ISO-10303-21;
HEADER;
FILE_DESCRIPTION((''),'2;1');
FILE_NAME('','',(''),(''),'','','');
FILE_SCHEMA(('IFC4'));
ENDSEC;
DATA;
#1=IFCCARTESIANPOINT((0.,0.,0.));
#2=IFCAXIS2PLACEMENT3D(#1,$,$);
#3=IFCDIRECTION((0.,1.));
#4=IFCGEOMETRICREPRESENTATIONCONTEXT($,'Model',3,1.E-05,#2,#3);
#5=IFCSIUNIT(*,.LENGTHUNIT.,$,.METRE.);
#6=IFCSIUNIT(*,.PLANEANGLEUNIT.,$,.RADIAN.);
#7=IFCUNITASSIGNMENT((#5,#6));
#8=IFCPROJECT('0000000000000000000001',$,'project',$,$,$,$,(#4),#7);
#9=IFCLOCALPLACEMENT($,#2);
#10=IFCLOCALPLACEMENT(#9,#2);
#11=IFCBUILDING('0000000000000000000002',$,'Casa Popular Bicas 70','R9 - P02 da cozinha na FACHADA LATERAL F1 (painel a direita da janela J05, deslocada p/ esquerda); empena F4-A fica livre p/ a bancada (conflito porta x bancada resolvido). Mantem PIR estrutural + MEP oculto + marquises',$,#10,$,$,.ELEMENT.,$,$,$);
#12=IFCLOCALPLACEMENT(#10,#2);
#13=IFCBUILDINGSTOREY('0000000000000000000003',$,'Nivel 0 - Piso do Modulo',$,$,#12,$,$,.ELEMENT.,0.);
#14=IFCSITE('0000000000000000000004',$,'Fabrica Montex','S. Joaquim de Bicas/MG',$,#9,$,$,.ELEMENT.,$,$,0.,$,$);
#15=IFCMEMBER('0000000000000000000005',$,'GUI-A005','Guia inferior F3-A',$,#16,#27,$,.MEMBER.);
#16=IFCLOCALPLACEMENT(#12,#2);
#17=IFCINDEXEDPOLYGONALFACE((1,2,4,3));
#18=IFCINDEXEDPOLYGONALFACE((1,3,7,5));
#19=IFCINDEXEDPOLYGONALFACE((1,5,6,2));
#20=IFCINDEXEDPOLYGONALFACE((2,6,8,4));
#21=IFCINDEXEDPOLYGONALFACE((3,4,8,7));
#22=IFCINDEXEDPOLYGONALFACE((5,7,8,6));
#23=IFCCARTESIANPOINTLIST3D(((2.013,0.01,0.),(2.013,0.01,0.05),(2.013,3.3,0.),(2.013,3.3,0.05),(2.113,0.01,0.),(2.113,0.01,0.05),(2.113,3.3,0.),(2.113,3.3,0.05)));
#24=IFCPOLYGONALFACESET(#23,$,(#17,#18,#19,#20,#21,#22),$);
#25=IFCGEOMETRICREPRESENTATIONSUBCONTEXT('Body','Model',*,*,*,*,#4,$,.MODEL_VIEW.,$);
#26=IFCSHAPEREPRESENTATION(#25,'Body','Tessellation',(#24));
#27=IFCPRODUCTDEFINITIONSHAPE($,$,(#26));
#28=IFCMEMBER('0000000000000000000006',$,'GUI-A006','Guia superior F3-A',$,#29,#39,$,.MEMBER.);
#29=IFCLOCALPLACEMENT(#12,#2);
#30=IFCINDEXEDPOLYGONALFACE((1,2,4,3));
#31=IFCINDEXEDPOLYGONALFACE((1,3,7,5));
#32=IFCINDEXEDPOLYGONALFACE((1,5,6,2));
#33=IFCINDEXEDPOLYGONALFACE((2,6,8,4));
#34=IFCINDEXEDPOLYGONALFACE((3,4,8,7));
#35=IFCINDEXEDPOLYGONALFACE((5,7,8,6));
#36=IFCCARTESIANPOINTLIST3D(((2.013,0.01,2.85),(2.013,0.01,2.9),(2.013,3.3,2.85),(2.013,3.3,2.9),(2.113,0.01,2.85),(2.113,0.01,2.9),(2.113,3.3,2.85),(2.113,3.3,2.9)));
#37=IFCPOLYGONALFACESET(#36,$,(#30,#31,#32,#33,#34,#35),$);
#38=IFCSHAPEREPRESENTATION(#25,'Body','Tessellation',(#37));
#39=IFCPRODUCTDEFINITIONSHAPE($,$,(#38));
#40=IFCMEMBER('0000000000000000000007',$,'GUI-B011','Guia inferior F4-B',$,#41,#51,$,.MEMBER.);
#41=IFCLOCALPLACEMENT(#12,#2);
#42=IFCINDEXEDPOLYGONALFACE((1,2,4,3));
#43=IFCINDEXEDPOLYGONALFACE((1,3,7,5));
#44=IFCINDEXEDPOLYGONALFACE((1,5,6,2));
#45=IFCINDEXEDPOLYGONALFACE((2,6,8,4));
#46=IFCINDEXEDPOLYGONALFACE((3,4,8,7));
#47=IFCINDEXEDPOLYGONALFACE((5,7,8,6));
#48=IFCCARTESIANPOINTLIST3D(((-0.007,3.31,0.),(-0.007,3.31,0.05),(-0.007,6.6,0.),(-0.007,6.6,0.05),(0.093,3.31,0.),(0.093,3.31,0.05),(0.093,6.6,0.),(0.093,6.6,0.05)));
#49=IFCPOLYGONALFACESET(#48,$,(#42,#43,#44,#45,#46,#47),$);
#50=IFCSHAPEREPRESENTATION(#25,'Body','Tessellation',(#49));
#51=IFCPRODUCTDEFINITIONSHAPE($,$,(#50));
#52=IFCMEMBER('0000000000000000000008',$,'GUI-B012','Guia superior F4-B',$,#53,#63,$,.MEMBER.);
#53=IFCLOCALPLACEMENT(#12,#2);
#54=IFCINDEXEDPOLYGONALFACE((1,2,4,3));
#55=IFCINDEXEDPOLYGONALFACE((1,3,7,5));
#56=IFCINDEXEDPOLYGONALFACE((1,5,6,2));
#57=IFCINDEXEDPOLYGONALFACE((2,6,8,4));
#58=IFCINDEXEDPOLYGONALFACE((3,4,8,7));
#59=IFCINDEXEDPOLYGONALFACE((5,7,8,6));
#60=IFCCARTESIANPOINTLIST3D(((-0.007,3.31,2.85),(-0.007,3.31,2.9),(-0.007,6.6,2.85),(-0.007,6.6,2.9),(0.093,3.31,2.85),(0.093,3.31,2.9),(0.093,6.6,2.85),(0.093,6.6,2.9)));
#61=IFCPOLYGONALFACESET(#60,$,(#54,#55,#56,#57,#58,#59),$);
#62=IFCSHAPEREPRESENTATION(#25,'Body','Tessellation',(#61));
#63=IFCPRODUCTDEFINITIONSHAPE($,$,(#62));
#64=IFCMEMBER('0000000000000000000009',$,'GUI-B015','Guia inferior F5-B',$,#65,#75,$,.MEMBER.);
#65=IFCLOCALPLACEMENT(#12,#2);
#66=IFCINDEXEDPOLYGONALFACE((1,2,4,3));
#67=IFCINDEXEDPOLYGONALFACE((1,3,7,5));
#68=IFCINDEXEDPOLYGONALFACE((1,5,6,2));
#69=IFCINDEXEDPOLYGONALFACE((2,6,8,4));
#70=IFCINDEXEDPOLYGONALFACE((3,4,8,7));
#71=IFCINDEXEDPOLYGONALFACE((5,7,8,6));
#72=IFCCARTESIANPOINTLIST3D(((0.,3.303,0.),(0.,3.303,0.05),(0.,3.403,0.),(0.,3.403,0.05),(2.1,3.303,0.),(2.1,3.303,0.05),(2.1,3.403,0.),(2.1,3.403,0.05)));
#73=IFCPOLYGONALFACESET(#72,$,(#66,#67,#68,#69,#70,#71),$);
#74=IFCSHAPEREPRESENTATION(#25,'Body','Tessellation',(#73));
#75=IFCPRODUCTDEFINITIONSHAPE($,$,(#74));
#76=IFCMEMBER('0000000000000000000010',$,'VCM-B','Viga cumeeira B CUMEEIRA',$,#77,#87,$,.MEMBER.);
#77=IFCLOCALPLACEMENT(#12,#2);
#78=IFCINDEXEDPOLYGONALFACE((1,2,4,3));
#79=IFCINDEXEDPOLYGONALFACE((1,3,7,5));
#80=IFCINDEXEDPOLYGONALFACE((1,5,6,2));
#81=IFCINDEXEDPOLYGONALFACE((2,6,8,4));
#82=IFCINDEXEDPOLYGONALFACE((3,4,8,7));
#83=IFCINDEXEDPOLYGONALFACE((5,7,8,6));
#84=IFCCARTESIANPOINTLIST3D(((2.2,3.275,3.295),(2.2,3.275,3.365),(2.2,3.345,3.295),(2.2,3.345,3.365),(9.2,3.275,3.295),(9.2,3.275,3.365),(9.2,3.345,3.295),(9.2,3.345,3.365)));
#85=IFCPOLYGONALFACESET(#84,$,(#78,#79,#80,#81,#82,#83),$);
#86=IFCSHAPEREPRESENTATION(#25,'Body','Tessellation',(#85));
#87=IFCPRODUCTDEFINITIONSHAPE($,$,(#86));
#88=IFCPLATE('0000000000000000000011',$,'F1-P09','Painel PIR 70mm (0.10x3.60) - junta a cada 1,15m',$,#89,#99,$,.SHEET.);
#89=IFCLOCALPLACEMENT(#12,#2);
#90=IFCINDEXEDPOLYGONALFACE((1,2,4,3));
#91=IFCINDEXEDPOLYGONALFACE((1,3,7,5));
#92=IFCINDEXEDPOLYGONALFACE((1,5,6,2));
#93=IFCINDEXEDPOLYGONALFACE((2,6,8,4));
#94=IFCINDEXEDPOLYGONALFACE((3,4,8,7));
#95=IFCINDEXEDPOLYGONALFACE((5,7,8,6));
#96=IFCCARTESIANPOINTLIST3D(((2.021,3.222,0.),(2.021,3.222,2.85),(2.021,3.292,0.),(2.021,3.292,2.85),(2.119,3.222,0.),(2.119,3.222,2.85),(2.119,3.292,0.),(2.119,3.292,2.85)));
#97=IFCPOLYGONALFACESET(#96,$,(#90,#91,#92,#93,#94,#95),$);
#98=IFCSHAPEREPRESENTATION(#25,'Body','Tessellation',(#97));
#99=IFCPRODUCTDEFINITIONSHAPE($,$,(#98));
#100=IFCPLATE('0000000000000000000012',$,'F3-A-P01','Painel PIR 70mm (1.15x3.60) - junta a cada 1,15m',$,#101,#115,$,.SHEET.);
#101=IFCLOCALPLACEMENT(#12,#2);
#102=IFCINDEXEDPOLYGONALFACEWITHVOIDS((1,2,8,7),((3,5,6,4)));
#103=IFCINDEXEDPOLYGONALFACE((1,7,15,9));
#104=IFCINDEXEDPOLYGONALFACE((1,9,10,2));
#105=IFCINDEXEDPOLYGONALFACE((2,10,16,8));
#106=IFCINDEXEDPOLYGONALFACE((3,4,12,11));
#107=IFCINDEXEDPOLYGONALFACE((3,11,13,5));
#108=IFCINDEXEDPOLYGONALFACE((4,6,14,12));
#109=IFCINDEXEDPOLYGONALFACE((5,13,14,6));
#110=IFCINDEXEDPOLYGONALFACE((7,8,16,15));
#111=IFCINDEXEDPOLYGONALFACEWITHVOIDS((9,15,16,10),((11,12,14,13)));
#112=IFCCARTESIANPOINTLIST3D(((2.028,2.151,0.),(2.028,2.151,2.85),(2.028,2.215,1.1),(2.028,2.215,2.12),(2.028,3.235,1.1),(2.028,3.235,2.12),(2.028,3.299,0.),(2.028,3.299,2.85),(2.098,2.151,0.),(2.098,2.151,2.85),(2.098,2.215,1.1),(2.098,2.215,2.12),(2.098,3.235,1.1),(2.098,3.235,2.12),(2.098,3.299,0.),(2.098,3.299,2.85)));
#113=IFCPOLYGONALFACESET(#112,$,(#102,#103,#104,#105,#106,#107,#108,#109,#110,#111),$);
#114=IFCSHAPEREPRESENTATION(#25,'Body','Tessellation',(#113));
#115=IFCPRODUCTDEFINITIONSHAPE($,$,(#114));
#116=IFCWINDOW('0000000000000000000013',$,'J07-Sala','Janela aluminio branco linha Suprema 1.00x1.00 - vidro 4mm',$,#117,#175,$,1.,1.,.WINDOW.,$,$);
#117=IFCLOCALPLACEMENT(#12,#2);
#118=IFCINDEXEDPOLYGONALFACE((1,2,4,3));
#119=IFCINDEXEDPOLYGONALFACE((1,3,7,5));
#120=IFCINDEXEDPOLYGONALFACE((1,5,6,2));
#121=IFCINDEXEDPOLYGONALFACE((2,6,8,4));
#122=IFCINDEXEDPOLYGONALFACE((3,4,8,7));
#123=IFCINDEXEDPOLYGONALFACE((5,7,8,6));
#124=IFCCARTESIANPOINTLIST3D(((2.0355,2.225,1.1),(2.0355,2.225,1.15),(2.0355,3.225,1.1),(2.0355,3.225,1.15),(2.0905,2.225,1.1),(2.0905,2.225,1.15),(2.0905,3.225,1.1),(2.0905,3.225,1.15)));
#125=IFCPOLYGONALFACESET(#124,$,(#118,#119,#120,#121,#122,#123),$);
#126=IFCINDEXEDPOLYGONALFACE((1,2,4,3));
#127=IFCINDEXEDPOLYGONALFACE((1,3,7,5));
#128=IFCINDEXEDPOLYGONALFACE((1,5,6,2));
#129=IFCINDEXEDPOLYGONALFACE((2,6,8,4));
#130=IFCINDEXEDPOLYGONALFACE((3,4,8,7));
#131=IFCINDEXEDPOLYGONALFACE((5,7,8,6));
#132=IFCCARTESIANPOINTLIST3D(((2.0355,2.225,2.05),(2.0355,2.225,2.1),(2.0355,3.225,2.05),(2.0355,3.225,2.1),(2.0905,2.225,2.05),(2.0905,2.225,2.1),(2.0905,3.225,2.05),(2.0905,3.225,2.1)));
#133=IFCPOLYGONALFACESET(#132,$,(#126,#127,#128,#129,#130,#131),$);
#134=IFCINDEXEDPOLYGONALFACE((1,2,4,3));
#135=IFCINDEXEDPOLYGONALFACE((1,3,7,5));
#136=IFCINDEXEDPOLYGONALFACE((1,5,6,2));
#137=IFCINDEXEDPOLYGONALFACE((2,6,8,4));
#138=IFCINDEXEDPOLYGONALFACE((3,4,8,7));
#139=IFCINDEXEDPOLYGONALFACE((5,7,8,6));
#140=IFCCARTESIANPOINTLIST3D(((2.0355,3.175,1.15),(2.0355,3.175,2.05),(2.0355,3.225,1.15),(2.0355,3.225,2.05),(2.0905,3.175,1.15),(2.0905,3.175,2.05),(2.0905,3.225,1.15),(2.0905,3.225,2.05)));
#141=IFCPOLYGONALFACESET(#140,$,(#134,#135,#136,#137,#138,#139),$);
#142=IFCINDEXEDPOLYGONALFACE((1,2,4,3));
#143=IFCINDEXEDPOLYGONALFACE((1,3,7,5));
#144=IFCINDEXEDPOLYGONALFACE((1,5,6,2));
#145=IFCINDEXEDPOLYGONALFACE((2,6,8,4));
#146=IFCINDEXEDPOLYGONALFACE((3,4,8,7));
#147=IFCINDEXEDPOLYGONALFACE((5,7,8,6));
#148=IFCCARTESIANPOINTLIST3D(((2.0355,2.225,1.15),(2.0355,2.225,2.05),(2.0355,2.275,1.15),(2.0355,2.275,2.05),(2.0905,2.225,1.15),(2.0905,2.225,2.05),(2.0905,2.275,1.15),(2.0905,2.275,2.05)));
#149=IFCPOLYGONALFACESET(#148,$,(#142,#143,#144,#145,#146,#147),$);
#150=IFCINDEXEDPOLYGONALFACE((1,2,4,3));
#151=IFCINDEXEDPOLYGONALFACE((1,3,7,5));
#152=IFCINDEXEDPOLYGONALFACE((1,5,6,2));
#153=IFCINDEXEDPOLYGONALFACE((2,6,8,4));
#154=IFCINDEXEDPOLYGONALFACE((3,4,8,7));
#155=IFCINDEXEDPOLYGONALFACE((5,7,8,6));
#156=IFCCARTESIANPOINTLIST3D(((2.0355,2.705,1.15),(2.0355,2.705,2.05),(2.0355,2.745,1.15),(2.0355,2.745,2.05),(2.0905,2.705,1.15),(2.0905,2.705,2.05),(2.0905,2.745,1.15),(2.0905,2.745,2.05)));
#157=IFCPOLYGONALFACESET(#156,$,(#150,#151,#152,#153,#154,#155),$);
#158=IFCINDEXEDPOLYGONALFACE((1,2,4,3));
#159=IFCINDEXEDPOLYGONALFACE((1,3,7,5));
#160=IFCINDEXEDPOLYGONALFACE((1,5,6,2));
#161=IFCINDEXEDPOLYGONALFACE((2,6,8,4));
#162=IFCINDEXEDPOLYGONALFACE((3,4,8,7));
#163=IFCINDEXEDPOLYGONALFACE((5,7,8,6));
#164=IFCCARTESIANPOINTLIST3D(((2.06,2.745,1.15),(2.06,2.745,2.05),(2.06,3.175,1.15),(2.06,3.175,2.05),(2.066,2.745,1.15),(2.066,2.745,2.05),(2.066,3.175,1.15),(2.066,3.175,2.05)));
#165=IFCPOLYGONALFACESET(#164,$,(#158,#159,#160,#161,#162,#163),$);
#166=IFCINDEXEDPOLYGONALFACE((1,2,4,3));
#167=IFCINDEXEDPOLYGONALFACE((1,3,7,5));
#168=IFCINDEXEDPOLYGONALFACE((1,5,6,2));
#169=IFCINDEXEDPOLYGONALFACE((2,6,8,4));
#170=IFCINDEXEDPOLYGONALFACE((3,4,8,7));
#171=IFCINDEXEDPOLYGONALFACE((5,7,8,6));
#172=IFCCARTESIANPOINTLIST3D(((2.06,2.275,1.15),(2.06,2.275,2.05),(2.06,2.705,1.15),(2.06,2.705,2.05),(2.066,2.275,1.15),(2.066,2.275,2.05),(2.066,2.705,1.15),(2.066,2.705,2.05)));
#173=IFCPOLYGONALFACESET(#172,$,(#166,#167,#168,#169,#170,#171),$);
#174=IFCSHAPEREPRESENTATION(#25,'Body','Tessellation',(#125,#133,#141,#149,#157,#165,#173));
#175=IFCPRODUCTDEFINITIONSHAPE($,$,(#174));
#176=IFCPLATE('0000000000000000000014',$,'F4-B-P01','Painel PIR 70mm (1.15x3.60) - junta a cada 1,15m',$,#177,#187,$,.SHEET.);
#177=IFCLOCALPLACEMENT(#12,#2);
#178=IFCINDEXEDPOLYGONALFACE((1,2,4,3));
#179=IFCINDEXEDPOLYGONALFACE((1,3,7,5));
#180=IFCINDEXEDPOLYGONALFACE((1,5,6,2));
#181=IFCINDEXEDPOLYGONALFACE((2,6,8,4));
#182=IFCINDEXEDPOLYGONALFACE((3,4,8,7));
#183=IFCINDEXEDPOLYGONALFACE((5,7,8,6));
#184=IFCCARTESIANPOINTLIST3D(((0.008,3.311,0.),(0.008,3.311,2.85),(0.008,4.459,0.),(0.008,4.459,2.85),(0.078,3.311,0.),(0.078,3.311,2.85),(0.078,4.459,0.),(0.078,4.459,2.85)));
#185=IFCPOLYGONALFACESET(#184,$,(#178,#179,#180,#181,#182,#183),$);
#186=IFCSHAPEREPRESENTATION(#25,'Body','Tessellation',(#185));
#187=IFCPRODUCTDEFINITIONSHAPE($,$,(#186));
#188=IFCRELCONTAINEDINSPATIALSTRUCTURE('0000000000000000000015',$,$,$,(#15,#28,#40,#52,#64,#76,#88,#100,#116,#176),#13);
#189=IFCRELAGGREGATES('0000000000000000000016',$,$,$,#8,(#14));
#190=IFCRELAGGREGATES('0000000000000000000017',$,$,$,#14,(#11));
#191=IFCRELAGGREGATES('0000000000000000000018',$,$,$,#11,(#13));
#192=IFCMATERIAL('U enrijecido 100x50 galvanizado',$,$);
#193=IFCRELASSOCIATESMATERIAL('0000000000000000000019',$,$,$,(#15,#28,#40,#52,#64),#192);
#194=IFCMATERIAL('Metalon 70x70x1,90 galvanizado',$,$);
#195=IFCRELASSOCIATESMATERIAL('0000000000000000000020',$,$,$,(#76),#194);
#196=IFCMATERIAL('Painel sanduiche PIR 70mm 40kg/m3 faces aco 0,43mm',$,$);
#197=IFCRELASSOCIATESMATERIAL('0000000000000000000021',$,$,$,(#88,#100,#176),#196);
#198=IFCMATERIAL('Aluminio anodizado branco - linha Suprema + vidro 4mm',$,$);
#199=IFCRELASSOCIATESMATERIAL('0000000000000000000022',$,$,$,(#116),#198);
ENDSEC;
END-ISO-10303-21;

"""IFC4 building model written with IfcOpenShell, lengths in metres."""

from ifc_helpers import new_model, si_unit, direction, frame, frame_2d, origin, origin_2d, place, context, subcontext, project, spatial, rectangle, extrude, material, element, fill, save


model = new_model("IFC4")

# Units and contexts
model_context = context("Model", 3, precision=1e-05, world=origin(), true_north=direction((0.0, 1.0)))
body_context = subcontext(model_context, "Body", "Model", "MODEL_VIEW")
ifc_project = project(units=[si_unit("LENGTHUNIT", "METRE"), si_unit("PLANEANGLEUNIT", "RADIAN")], contexts=[model_context])

# Site, building, storey
site_placement = place(None, origin())
site = spatial("IfcSite", under=ifc_project, at=site_placement, Name="Fabrica Montex", Description="S. Joaquim de Bicas/MG", CompositionType="ELEMENT", RefElevation=0.0)
building_placement = place(site_placement, origin())
building = spatial("IfcBuilding", under=site, at=building_placement, Name="Casa Popular Bicas 70", Description="R9 - P02 da cozinha na FACHADA LATERAL F1 (painel a direita da janela J05, deslocada p/ esquerda); empena F4-A fica livre p/ a bancada (conflito porta x bancada resolvido). Mantem PIR estrutural + MEP oculto + marquises", CompositionType="ELEMENT")
storey_placement = place(building_placement, origin())
storey = spatial("IfcBuildingStorey", under=building, at=storey_placement, Name="Nivel 0 - Piso do Modulo", CompositionType="ELEMENT", Elevation=0.0)

# Members
ifc_material_1 = material(Name="U enrijecido 100x50 galvanizado")
for number, where, z_axis, x_axis, name, description in (
    (1, (2.063, 3.3, 0.025), (0.0, -1.0, 0.0), (0.0, 0.0, 1.0), "GUI-A005", "Guia inferior F3-A"),
    (2, (2.063, 3.3, 2.875), (0.0, -1.0, 0.0), (0.0, 0.0, 1.0), "GUI-A006", "Guia superior F3-A"),
):
    element("IfcMember", number, at=place(None, frame(where, z_axis=z_axis, x_axis=x_axis)), inside=storey, material=ifc_material_1, Name=name, Description=description, PredefinedType="MEMBER", context=body_context, shape_type="SweptSolid", body=[
        extrude(rectangle(XDim=0.05, YDim=0.1, at=origin_2d()), origin(), (0.0, 0.0, 1.0), 3.29),
    ])
for number, where, z_axis, x_axis, name, description in (
    (3, (0.043, 3.31, 0.025), (0.0, 1.0, 0.0), (0.0, 0.0, 1.0), "GUI-B011", "Guia inferior F4-B"),
    (4, (0.043, 3.31, 2.875), (0.0, 1.0, 0.0), (0.0, 0.0, 1.0), "GUI-B012", "Guia superior F4-B"),
):
    element("IfcMember", number, at=place(storey_placement, frame(where, z_axis=z_axis, x_axis=x_axis)), inside=storey, material=ifc_material_1, Name=name, Description=description, PredefinedType="MEMBER", context=body_context, shape_type="SweptSolid", body=[
        extrude(rectangle(XDim=0.05, YDim=0.1, at=origin_2d()), origin(), (0.0, 0.0, 1.0), 3.29),
    ])
member_1_placement = place(storey_placement, frame((0.0, 3.353, 0.025), z_axis=(1.0, 0.0, 0.0), x_axis=(0.0, 0.0, 1.0)))
element("IfcMember", 5, at=member_1_placement, inside=storey, material=ifc_material_1, Name="GUI-B015", Description="Guia inferior F5-B", PredefinedType="MEMBER", context=body_context, shape_type="SweptSolid", body=[
    extrude(rectangle(XDim=0.05, YDim=0.1, at=origin_2d()), origin(), (0.0, 0.0, 1.0), 2.1),
])
ifc_material_2 = material(Name="Metalon 70x70x1,90 galvanizado")
member_2_placement = place(storey_placement, frame((2.2, 3.31, 3.33), z_axis=(1.0, 0.0, 0.0), x_axis=(0.0, 0.0, 1.0)))
element("IfcMember", 6, at=member_2_placement, inside=storey, material=ifc_material_2, Name="VCM-B", Description="Viga cumeeira B CUMEEIRA", PredefinedType="MEMBER", context=body_context, shape_type="SweptSolid", body=[
    extrude(rectangle(XDim=0.07, YDim=0.07, at=origin_2d()), origin(), (0.0, 0.0, 1.0), 7.0),
])

# Plate
ifc_material_3 = material(Name="Painel sanduiche PIR 70mm 40kg/m3 faces aco 0,43mm")
plate_1_placement = place(None, frame((2.119, 3.257, 0.0), z_axis=(0.0, 0.0, 1.0), x_axis=(-1.0, 0.0, 0.0)))
element("IfcPlate", 7, at=plate_1_placement, inside=storey, material=ifc_material_3, Name="F1-P09", Description="Painel PIR 70mm (0.10x3.60) - junta a cada 1,15m", PredefinedType="SHEET", context=body_context, shape_type="SweptSolid", body=[
    extrude(rectangle(XDim=0.098, YDim=0.07, at=frame_2d((0.049, 0.0))), origin(), (0.0, 0.0, 1.0), 2.85),
])

# Plate, opening, window
plate_2_placement = place(None, frame((2.063, 3.299, 0.0), z_axis=(0.0, 0.0, 1.0), x_axis=(0.0, -1.0, 0.0)))
plate_2 = element("IfcPlate", 8, at=plate_2_placement, inside=storey, material=ifc_material_3, Name="F3-A-P01", Description="Painel PIR 70mm (1.15x3.60) - junta a cada 1,15m", PredefinedType="SHEET", context=body_context, shape_type="SweptSolid", body=[
    extrude(rectangle(XDim=1.148, YDim=0.07, at=frame_2d((0.574, 0.0))), origin(), (0.0, 0.0, 1.0), 2.85),
])
opening_1_placement = place(None, frame((2.063, 3.225, 1.1), z_axis=(0.0, 0.0, 1.0), x_axis=(0.0, -1.0, 0.0)))
opening_1 = element("IfcOpeningElement", 9, at=opening_1_placement, cuts=plate_2, PredefinedType="OPENING", context=body_context, shape_type="SweptSolid", body=[
    extrude(rectangle(XDim=1.02, YDim=0.3, at=frame_2d((0.5, 0.0))), origin(), (0.0, 0.0, 1.0), 1.02),
])
ifc_material_4 = material(Name="Aluminio anodizado branco - linha Suprema + vidro 4mm")
window_placement = place(None, frame((2.063, 3.225, 1.1), z_axis=(0.0, 0.0, 1.0), x_axis=(0.0, -1.0, 0.0)))
window = element("IfcWindow", 10, at=window_placement, inside=storey, material=ifc_material_4, Name="J07-Sala", Description="Janela aluminio branco linha Suprema 1.00x1.00 - vidro 4mm", OverallHeight=1.0, OverallWidth=1.0, PredefinedType="WINDOW", context=body_context, shape_type="SweptSolid", body=[
    extrude(rectangle(XDim=1.0, YDim=0.055, at=frame_2d((0.5, 0.0))), origin(), (0.0, 0.0, 1.0), 0.05),
    extrude(rectangle(XDim=1.0, YDim=0.055, at=frame_2d((0.5, 0.0))), frame((0.0, 0.0, 0.95)), (0.0, 0.0, 1.0), 0.05),
    extrude(rectangle(XDim=0.05, YDim=0.055, at=frame_2d((0.025, 0.0))), frame((0.0, 0.0, 0.05)), (0.0, 0.0, 1.0), 0.9),
    extrude(rectangle(XDim=0.05, YDim=0.055, at=frame_2d((0.975, 0.0))), frame((0.0, 0.0, 0.05)), (0.0, 0.0, 1.0), 0.9),
    extrude(rectangle(XDim=0.04, YDim=0.055, at=frame_2d((0.5, 0.0))), frame((0.0, 0.0, 0.05)), (0.0, 0.0, 1.0), 0.9),
    extrude(rectangle(XDim=0.43, YDim=0.006, at=frame_2d((0.265, 0.0))), frame((0.0, 0.0, 0.05)), (0.0, 0.0, 1.0), 0.9),
    extrude(rectangle(XDim=0.43, YDim=0.006, at=frame_2d((0.735, 0.0))), frame((0.0, 0.0, 0.05)), (0.0, 0.0, 1.0), 0.9),
])
fill(opening_1, window)

# Plate
plate_3_placement = place(storey_placement, frame((0.043, 3.311, 0.0), x_axis=(0.0, 1.0, 0.0)))
element("IfcPlate", 11, at=plate_3_placement, inside=storey, material=ifc_material_3, Name="F4-B-P01", Description="Painel PIR 70mm (1.15x3.60) - junta a cada 1,15m", PredefinedType="SHEET", context=body_context, shape_type="SweptSolid", body=[
    extrude(rectangle(XDim=1.148, YDim=0.07, at=frame_2d((0.574, 0.0))), origin(), (0.0, 0.0, 1.0), 2.85),
])

save(model, "model.ifc")
